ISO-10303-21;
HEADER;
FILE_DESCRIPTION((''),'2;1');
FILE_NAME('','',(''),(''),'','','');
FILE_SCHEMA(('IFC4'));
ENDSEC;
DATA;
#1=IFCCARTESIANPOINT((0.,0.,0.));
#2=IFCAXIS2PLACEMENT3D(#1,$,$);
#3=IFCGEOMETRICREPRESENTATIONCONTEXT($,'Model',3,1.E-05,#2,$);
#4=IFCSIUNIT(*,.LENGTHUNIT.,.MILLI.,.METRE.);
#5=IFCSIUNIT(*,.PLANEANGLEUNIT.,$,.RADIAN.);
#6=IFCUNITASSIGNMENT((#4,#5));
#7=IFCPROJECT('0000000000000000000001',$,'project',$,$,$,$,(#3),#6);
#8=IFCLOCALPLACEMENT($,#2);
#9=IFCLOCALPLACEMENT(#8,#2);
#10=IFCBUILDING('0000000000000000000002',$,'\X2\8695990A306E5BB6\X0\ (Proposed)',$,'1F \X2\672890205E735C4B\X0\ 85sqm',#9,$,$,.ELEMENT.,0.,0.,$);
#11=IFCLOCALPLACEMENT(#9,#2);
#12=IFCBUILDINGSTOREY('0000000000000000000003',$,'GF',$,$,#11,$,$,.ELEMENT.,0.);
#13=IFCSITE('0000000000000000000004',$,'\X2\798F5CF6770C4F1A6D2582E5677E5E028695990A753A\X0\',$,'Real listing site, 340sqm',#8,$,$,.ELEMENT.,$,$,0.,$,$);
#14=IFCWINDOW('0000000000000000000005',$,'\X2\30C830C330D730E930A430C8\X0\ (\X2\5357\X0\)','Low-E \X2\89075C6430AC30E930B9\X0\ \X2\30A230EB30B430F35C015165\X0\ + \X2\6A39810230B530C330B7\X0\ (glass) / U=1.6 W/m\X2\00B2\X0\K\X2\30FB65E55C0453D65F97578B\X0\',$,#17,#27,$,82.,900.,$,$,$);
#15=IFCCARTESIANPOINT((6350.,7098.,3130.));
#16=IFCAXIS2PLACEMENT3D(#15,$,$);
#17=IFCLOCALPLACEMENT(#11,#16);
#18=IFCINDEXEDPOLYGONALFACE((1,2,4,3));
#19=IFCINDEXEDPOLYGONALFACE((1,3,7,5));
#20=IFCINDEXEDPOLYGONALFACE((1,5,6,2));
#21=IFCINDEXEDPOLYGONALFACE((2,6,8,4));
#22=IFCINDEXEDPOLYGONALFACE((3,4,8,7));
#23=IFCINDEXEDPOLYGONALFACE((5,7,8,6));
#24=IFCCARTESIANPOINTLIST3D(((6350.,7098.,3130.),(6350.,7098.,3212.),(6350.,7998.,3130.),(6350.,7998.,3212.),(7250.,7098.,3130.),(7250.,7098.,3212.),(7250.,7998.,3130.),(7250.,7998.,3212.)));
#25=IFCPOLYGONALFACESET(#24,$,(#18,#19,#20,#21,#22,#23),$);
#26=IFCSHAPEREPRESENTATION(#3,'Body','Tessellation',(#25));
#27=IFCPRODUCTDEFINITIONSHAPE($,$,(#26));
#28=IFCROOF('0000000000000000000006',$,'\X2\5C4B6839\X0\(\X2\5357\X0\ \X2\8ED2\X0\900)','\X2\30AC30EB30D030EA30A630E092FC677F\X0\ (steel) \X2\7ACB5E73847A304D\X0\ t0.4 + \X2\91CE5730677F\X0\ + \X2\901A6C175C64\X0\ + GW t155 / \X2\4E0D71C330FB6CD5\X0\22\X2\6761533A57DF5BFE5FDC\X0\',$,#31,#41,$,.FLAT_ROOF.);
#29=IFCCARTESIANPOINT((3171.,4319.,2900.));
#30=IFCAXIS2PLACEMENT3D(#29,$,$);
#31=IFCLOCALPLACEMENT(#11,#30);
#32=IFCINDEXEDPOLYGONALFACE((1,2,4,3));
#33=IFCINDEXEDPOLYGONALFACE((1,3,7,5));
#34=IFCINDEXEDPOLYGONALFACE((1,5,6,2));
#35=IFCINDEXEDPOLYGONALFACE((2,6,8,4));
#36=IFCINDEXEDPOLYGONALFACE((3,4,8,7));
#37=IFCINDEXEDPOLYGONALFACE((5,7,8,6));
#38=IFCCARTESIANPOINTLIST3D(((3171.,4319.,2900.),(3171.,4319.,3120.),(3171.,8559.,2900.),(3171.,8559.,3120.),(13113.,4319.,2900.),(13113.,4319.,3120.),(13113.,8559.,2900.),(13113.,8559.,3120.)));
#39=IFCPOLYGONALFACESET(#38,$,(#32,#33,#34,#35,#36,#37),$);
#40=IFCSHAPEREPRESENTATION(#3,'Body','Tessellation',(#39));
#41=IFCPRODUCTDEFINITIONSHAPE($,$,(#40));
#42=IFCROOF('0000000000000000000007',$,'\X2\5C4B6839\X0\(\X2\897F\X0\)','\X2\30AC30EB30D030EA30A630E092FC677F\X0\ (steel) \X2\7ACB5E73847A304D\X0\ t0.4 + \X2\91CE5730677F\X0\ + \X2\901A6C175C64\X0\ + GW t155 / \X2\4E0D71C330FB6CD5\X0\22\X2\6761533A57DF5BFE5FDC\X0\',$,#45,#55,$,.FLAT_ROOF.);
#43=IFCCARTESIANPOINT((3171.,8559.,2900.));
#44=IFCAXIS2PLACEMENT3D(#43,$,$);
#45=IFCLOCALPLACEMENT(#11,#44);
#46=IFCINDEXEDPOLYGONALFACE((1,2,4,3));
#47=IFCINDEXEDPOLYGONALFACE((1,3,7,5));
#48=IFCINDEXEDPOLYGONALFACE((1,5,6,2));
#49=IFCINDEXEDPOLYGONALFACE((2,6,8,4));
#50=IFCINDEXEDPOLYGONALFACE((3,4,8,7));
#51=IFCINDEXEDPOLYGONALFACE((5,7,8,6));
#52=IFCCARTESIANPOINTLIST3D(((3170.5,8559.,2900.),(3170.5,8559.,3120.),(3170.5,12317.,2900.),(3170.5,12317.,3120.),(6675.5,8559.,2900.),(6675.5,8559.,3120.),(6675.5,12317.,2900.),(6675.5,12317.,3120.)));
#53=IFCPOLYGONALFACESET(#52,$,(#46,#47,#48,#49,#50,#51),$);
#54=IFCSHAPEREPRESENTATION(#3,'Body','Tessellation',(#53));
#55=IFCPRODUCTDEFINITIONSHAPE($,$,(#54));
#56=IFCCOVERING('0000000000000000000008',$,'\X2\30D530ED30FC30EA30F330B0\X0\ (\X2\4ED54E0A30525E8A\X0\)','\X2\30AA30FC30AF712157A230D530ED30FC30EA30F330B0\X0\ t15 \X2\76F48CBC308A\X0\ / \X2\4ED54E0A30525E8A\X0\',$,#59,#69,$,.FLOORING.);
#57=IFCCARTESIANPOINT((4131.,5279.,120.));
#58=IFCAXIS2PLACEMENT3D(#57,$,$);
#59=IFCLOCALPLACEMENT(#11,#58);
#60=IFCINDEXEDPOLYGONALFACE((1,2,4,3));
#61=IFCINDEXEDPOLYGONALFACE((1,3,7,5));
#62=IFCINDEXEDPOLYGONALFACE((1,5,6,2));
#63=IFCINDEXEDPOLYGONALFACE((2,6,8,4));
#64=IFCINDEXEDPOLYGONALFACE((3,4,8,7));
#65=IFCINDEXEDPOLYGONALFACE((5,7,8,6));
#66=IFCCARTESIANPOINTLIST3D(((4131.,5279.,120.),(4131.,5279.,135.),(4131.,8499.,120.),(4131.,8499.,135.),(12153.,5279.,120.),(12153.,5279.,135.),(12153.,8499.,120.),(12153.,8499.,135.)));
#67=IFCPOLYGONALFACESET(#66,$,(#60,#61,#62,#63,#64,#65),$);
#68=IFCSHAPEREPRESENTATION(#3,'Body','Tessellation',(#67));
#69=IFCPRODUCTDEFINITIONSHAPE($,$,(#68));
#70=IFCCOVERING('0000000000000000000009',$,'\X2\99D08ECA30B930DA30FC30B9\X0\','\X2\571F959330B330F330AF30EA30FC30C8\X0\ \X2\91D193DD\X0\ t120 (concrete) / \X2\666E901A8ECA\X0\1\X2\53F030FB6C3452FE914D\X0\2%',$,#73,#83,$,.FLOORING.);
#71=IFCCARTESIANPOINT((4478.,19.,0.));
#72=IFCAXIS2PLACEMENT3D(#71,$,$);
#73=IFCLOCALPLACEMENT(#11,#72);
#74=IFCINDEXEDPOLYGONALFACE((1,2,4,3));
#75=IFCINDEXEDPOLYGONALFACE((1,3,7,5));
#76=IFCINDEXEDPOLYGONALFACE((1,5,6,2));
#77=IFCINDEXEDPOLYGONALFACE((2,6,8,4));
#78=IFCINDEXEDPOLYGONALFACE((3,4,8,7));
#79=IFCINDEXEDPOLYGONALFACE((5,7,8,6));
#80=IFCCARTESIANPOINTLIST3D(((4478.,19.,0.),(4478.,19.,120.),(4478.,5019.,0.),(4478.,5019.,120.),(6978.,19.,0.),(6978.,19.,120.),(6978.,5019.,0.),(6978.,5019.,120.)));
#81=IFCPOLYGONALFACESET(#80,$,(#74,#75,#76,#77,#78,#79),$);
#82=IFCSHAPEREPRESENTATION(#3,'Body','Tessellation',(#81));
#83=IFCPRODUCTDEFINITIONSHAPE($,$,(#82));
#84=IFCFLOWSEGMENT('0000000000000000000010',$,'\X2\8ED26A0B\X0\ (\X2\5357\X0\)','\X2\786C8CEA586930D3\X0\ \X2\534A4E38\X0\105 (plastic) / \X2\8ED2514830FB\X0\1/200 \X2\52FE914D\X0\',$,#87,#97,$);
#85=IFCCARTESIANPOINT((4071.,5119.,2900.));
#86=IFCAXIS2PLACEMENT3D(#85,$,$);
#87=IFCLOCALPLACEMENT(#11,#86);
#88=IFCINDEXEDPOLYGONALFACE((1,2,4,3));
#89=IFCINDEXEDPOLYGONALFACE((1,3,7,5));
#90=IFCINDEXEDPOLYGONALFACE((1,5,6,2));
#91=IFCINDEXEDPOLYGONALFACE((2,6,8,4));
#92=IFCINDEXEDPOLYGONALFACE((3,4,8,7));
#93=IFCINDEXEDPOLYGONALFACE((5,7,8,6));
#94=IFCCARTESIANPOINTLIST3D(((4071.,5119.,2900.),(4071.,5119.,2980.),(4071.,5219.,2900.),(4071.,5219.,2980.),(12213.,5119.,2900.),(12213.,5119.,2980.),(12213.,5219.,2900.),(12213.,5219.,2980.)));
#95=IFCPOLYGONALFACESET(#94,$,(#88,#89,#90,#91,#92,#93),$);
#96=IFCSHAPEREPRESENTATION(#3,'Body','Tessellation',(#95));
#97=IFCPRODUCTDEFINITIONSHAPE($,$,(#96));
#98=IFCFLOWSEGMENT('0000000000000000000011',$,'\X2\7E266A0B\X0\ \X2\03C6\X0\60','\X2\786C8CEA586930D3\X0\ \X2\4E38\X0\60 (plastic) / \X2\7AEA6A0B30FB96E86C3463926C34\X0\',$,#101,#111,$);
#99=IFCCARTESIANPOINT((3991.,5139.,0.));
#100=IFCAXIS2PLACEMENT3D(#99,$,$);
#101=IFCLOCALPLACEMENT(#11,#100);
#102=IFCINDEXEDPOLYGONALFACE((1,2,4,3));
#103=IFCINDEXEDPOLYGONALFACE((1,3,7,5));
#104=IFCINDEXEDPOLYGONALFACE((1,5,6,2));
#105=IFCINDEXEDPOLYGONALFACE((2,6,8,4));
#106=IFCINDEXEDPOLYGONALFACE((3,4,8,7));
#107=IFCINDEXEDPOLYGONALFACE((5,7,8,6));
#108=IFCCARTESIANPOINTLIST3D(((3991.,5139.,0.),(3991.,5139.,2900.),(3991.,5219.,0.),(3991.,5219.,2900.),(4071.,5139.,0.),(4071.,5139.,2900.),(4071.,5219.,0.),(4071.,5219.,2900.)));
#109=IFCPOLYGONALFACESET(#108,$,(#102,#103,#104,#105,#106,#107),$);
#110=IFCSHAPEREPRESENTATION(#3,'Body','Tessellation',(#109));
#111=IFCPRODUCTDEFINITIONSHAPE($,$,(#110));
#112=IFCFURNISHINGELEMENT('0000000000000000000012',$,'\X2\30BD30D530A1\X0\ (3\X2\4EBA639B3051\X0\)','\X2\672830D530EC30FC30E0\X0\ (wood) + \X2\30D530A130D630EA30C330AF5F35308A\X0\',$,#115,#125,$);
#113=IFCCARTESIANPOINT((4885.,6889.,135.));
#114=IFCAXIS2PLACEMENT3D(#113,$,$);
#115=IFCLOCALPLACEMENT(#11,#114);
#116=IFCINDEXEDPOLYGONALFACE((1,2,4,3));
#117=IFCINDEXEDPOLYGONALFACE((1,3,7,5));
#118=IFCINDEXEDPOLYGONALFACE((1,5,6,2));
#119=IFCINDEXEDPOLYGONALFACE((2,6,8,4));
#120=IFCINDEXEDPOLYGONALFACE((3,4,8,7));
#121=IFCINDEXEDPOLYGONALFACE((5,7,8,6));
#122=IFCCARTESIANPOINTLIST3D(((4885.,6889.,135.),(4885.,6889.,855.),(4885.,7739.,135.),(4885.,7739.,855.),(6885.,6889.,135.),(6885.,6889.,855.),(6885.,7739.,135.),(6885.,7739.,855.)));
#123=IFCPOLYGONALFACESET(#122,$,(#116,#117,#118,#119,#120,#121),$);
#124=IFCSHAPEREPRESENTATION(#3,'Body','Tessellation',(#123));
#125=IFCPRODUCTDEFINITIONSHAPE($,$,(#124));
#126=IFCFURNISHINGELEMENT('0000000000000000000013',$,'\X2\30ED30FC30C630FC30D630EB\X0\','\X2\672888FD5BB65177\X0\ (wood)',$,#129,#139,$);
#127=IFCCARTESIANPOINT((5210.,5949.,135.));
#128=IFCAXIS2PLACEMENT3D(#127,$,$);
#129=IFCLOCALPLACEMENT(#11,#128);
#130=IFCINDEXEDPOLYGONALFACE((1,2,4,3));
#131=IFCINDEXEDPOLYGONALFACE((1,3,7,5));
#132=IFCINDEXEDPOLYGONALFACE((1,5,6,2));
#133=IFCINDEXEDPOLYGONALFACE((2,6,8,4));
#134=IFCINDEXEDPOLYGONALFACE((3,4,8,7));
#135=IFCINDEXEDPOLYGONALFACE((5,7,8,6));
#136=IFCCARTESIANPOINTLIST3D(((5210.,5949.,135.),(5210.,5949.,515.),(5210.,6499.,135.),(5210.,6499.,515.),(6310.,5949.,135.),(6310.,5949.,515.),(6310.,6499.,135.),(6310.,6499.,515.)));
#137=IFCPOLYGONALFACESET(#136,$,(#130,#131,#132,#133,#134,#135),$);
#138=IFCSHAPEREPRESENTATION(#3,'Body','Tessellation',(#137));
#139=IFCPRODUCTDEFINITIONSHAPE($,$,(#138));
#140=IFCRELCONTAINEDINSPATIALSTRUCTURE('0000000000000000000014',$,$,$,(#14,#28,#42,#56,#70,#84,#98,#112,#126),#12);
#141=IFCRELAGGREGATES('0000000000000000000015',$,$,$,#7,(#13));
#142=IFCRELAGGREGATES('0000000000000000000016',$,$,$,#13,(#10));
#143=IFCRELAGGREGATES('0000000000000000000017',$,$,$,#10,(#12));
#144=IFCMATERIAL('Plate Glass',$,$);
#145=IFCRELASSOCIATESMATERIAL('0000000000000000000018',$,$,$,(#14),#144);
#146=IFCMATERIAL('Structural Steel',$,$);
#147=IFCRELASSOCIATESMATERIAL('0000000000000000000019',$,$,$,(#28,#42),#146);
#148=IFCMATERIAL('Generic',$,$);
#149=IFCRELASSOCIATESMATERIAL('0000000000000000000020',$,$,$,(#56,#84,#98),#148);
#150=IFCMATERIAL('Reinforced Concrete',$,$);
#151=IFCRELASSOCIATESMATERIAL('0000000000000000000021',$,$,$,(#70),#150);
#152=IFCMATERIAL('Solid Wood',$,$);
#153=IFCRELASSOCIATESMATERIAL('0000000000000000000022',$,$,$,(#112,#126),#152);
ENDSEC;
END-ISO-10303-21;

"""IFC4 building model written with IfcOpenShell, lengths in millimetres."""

from ifc_helpers import new_model, si_unit, frame, frame_2d, origin, place, context, project, spatial, rectangle, extrude, material, element, save


model = new_model("IFC4")

# Units and contexts
model_context = context("Model", 3, precision=1e-05, world=origin())
ifc_project = project(units=[si_unit("LENGTHUNIT", "METRE", prefix="MILLI"), si_unit("PLANEANGLEUNIT", "RADIAN")], contexts=[model_context])

# Site, building, storey
site_placement = place(None, origin())
site = spatial("IfcSite", under=ifc_project, at=site_placement, Name="福島県会津若松市蚕養町", ObjectType="Real listing site, 340sqm", CompositionType="ELEMENT", RefElevation=0.0)
building_placement = place(site_placement, origin())
building = spatial("IfcBuilding", under=site, at=building_placement, Name="蚕養の家 (Proposed)", ObjectType="1F 木造平屋 85sqm", CompositionType="ELEMENT", ElevationOfRefHeight=0.0, ElevationOfTerrain=0.0)
storey_placement = place(building_placement, origin())
storey = spatial("IfcBuildingStorey", under=building, at=storey_placement, Name="GF", CompositionType="ELEMENT", Elevation=0.0)

# Shared definitions
ifc_material_1 = material(Name="Solid Wood")

# Shared definitions
ifc_material_2 = material(Name="Reinforced Concrete")

# Shared definitions
ifc_material_3 = material(Name="Plate Glass")

# Window
window_1_placement = place(storey_placement, frame((6350.0, 7098.0, 3130.0)))
element("IfcWindow", 1, at=window_1_placement, inside=storey, material=ifc_material_3, Name="トップライト (南)", Description="Low-E 複層ガラス アルゴン封入 + 樹脂サッシ (glass) / U=1.6 W/m²K・日射取得型", OverallHeight=82.0, OverallWidth=900.0, context=model_context, shape_type="SweptSolid", body=[
    extrude(rectangle(XDim=900.0, YDim=900.0, at=frame_2d((450.0, 450.0))), frame((6350.0, 7098.0, 3130.0)), (0.0, 0.0, 1.0), 82.0),
])

# Roofs
ifc_material_4 = material(Name="Structural Steel")
roof_1_placement = place(storey_placement, frame((3171.0, 4319.0, 2900.0)))
element("IfcRoof", 2, at=roof_1_placement, inside=storey, material=ifc_material_4, Name="屋根(南 軒900)", Description="ガルバリウム鋼板 (steel) 立平葺き t0.4 + 野地板 + 通気層 + GW t155 / 不燃・法22条区域対応", PredefinedType="FLAT_ROOF", context=model_context, shape_type="SweptSolid", body=[
    extrude(rectangle(XDim=9942.0, YDim=4240.0, at=frame_2d((4971.0, 2120.0))), frame((3171.0, 4319.0, 2900.0)), (0.0, 0.0, 1.0), 220.0),
])
roof_2_placement = place(storey_placement, frame((3171.0, 8559.0, 2900.0)))
element("IfcRoof", 3, at=roof_2_placement, inside=storey, material=ifc_material_4, Name="屋根(西)", Description="ガルバリウム鋼板 (steel) 立平葺き t0.4 + 野地板 + 通気層 + GW t155 / 不燃・法22条区域対応", PredefinedType="FLAT_ROOF", context=model_context, shape_type="SweptSolid", body=[
    extrude(rectangle(XDim=3505.0, YDim=3758.0, at=frame_2d((1752.0, 1879.0))), frame((3171.0, 8559.0, 2900.0)), (0.0, 0.0, 1.0), 220.0),
])

# Coverings
ifc_material_5 = material(Name="Generic")
covering_1_placement = place(storey_placement, frame((4131.0, 5279.0, 120.0)))
element("IfcCovering", 4, at=covering_1_placement, inside=storey, material=ifc_material_5, Name="フローリング (仕上げ床)", Description="オーク無垢フローリング t15 直貼り / 仕上げ床", PredefinedType="FLOORING", context=model_context, shape_type="SweptSolid", body=[
    extrude(rectangle(XDim=8022.0, YDim=3220.0, at=frame_2d((4011.0, 1610.0))), frame((4131.0, 5279.0, 120.0)), (0.0, 0.0, 1.0), 15.0),
])
covering_2_placement = place(storey_placement, frame((4478.0, 19.0, 0.0)))
element("IfcCovering", 5, at=covering_2_placement, inside=storey, material=ifc_material_2, Name="駐車スペース", Description="土間コンクリート 金鏝 t120 (concrete) / 普通車1台・水勾配2%", PredefinedType="FLOORING", context=model_context, shape_type="SweptSolid", body=[
    extrude(rectangle(XDim=2500.0, YDim=5000.0, at=frame_2d((1250.0, 2500.0))), frame((4478.0, 19.0, 0.0)), (0.0, 0.0, 1.0), 120.0),
])

# Flow segments
flow_segment_1_placement = place(storey_placement, frame((4071.0, 5119.0, 2900.0)))
element("IfcFlowSegment", 6, at=flow_segment_1_placement, inside=storey, material=ifc_material_5, Name="軒樋 (南)", Description="硬質塩ビ 半丸105 (plastic) / 軒先・1/200 勾配", context=model_context, shape_type="SweptSolid", body=[
    extrude(rectangle(XDim=8142.0, YDim=100.0, at=frame_2d((4071.0, 50.0))), frame((4071.0, 5119.0, 2900.0)), (0.0, 0.0, 1.0), 80.0),
])
flow_segment_2_placement = place(storey_placement, frame((3991.0, 5139.0, 0.0)))
element("IfcFlowSegment", 7, at=flow_segment_2_placement, inside=storey, material=ifc_material_5, Name="縦樋 φ60", Description="硬質塩ビ 丸60 (plastic) / 竪樋・雨水排水", context=model_context, shape_type="SweptSolid", body=[
    extrude(rectangle(XDim=80.0, YDim=80.0, at=frame_2d((40.0, 40.0))), frame((3991.0, 5139.0, 0.0)), (0.0, 0.0, 1.0), 2900.0),
])

# Furnishing elements
furnishing_1_placement = place(storey_placement, frame((4885.0, 6889.0, 135.0)))
element("IfcFurnishingElement", 8, at=furnishing_1_placement, inside=storey, material=ifc_material_1, Name="ソファ (3人掛け)", Description="木フレーム (wood) + ファブリック張り", context=model_context, shape_type="SweptSolid", body=[
    extrude(rectangle(XDim=2000.0, YDim=850.0, at=frame_2d((1000.0, 425.0))), frame((4885.0, 6889.0, 135.0)), (0.0, 0.0, 1.0), 720.0),
])
furnishing_2_placement = place(storey_placement, frame((5210.0, 5949.0, 135.0)))
element("IfcFurnishingElement", 9, at=furnishing_2_placement, inside=storey, material=ifc_material_1, Name="ローテーブル", Description="木製家具 (wood)", context=model_context, shape_type="SweptSolid", body=[
    extrude(rectangle(XDim=1100.0, YDim=550.0, at=frame_2d((550.0, 275.0))), frame((5210.0, 5949.0, 135.0)), (0.0, 0.0, 1.0), 380.0),
])

save(model, "model.ifc")
